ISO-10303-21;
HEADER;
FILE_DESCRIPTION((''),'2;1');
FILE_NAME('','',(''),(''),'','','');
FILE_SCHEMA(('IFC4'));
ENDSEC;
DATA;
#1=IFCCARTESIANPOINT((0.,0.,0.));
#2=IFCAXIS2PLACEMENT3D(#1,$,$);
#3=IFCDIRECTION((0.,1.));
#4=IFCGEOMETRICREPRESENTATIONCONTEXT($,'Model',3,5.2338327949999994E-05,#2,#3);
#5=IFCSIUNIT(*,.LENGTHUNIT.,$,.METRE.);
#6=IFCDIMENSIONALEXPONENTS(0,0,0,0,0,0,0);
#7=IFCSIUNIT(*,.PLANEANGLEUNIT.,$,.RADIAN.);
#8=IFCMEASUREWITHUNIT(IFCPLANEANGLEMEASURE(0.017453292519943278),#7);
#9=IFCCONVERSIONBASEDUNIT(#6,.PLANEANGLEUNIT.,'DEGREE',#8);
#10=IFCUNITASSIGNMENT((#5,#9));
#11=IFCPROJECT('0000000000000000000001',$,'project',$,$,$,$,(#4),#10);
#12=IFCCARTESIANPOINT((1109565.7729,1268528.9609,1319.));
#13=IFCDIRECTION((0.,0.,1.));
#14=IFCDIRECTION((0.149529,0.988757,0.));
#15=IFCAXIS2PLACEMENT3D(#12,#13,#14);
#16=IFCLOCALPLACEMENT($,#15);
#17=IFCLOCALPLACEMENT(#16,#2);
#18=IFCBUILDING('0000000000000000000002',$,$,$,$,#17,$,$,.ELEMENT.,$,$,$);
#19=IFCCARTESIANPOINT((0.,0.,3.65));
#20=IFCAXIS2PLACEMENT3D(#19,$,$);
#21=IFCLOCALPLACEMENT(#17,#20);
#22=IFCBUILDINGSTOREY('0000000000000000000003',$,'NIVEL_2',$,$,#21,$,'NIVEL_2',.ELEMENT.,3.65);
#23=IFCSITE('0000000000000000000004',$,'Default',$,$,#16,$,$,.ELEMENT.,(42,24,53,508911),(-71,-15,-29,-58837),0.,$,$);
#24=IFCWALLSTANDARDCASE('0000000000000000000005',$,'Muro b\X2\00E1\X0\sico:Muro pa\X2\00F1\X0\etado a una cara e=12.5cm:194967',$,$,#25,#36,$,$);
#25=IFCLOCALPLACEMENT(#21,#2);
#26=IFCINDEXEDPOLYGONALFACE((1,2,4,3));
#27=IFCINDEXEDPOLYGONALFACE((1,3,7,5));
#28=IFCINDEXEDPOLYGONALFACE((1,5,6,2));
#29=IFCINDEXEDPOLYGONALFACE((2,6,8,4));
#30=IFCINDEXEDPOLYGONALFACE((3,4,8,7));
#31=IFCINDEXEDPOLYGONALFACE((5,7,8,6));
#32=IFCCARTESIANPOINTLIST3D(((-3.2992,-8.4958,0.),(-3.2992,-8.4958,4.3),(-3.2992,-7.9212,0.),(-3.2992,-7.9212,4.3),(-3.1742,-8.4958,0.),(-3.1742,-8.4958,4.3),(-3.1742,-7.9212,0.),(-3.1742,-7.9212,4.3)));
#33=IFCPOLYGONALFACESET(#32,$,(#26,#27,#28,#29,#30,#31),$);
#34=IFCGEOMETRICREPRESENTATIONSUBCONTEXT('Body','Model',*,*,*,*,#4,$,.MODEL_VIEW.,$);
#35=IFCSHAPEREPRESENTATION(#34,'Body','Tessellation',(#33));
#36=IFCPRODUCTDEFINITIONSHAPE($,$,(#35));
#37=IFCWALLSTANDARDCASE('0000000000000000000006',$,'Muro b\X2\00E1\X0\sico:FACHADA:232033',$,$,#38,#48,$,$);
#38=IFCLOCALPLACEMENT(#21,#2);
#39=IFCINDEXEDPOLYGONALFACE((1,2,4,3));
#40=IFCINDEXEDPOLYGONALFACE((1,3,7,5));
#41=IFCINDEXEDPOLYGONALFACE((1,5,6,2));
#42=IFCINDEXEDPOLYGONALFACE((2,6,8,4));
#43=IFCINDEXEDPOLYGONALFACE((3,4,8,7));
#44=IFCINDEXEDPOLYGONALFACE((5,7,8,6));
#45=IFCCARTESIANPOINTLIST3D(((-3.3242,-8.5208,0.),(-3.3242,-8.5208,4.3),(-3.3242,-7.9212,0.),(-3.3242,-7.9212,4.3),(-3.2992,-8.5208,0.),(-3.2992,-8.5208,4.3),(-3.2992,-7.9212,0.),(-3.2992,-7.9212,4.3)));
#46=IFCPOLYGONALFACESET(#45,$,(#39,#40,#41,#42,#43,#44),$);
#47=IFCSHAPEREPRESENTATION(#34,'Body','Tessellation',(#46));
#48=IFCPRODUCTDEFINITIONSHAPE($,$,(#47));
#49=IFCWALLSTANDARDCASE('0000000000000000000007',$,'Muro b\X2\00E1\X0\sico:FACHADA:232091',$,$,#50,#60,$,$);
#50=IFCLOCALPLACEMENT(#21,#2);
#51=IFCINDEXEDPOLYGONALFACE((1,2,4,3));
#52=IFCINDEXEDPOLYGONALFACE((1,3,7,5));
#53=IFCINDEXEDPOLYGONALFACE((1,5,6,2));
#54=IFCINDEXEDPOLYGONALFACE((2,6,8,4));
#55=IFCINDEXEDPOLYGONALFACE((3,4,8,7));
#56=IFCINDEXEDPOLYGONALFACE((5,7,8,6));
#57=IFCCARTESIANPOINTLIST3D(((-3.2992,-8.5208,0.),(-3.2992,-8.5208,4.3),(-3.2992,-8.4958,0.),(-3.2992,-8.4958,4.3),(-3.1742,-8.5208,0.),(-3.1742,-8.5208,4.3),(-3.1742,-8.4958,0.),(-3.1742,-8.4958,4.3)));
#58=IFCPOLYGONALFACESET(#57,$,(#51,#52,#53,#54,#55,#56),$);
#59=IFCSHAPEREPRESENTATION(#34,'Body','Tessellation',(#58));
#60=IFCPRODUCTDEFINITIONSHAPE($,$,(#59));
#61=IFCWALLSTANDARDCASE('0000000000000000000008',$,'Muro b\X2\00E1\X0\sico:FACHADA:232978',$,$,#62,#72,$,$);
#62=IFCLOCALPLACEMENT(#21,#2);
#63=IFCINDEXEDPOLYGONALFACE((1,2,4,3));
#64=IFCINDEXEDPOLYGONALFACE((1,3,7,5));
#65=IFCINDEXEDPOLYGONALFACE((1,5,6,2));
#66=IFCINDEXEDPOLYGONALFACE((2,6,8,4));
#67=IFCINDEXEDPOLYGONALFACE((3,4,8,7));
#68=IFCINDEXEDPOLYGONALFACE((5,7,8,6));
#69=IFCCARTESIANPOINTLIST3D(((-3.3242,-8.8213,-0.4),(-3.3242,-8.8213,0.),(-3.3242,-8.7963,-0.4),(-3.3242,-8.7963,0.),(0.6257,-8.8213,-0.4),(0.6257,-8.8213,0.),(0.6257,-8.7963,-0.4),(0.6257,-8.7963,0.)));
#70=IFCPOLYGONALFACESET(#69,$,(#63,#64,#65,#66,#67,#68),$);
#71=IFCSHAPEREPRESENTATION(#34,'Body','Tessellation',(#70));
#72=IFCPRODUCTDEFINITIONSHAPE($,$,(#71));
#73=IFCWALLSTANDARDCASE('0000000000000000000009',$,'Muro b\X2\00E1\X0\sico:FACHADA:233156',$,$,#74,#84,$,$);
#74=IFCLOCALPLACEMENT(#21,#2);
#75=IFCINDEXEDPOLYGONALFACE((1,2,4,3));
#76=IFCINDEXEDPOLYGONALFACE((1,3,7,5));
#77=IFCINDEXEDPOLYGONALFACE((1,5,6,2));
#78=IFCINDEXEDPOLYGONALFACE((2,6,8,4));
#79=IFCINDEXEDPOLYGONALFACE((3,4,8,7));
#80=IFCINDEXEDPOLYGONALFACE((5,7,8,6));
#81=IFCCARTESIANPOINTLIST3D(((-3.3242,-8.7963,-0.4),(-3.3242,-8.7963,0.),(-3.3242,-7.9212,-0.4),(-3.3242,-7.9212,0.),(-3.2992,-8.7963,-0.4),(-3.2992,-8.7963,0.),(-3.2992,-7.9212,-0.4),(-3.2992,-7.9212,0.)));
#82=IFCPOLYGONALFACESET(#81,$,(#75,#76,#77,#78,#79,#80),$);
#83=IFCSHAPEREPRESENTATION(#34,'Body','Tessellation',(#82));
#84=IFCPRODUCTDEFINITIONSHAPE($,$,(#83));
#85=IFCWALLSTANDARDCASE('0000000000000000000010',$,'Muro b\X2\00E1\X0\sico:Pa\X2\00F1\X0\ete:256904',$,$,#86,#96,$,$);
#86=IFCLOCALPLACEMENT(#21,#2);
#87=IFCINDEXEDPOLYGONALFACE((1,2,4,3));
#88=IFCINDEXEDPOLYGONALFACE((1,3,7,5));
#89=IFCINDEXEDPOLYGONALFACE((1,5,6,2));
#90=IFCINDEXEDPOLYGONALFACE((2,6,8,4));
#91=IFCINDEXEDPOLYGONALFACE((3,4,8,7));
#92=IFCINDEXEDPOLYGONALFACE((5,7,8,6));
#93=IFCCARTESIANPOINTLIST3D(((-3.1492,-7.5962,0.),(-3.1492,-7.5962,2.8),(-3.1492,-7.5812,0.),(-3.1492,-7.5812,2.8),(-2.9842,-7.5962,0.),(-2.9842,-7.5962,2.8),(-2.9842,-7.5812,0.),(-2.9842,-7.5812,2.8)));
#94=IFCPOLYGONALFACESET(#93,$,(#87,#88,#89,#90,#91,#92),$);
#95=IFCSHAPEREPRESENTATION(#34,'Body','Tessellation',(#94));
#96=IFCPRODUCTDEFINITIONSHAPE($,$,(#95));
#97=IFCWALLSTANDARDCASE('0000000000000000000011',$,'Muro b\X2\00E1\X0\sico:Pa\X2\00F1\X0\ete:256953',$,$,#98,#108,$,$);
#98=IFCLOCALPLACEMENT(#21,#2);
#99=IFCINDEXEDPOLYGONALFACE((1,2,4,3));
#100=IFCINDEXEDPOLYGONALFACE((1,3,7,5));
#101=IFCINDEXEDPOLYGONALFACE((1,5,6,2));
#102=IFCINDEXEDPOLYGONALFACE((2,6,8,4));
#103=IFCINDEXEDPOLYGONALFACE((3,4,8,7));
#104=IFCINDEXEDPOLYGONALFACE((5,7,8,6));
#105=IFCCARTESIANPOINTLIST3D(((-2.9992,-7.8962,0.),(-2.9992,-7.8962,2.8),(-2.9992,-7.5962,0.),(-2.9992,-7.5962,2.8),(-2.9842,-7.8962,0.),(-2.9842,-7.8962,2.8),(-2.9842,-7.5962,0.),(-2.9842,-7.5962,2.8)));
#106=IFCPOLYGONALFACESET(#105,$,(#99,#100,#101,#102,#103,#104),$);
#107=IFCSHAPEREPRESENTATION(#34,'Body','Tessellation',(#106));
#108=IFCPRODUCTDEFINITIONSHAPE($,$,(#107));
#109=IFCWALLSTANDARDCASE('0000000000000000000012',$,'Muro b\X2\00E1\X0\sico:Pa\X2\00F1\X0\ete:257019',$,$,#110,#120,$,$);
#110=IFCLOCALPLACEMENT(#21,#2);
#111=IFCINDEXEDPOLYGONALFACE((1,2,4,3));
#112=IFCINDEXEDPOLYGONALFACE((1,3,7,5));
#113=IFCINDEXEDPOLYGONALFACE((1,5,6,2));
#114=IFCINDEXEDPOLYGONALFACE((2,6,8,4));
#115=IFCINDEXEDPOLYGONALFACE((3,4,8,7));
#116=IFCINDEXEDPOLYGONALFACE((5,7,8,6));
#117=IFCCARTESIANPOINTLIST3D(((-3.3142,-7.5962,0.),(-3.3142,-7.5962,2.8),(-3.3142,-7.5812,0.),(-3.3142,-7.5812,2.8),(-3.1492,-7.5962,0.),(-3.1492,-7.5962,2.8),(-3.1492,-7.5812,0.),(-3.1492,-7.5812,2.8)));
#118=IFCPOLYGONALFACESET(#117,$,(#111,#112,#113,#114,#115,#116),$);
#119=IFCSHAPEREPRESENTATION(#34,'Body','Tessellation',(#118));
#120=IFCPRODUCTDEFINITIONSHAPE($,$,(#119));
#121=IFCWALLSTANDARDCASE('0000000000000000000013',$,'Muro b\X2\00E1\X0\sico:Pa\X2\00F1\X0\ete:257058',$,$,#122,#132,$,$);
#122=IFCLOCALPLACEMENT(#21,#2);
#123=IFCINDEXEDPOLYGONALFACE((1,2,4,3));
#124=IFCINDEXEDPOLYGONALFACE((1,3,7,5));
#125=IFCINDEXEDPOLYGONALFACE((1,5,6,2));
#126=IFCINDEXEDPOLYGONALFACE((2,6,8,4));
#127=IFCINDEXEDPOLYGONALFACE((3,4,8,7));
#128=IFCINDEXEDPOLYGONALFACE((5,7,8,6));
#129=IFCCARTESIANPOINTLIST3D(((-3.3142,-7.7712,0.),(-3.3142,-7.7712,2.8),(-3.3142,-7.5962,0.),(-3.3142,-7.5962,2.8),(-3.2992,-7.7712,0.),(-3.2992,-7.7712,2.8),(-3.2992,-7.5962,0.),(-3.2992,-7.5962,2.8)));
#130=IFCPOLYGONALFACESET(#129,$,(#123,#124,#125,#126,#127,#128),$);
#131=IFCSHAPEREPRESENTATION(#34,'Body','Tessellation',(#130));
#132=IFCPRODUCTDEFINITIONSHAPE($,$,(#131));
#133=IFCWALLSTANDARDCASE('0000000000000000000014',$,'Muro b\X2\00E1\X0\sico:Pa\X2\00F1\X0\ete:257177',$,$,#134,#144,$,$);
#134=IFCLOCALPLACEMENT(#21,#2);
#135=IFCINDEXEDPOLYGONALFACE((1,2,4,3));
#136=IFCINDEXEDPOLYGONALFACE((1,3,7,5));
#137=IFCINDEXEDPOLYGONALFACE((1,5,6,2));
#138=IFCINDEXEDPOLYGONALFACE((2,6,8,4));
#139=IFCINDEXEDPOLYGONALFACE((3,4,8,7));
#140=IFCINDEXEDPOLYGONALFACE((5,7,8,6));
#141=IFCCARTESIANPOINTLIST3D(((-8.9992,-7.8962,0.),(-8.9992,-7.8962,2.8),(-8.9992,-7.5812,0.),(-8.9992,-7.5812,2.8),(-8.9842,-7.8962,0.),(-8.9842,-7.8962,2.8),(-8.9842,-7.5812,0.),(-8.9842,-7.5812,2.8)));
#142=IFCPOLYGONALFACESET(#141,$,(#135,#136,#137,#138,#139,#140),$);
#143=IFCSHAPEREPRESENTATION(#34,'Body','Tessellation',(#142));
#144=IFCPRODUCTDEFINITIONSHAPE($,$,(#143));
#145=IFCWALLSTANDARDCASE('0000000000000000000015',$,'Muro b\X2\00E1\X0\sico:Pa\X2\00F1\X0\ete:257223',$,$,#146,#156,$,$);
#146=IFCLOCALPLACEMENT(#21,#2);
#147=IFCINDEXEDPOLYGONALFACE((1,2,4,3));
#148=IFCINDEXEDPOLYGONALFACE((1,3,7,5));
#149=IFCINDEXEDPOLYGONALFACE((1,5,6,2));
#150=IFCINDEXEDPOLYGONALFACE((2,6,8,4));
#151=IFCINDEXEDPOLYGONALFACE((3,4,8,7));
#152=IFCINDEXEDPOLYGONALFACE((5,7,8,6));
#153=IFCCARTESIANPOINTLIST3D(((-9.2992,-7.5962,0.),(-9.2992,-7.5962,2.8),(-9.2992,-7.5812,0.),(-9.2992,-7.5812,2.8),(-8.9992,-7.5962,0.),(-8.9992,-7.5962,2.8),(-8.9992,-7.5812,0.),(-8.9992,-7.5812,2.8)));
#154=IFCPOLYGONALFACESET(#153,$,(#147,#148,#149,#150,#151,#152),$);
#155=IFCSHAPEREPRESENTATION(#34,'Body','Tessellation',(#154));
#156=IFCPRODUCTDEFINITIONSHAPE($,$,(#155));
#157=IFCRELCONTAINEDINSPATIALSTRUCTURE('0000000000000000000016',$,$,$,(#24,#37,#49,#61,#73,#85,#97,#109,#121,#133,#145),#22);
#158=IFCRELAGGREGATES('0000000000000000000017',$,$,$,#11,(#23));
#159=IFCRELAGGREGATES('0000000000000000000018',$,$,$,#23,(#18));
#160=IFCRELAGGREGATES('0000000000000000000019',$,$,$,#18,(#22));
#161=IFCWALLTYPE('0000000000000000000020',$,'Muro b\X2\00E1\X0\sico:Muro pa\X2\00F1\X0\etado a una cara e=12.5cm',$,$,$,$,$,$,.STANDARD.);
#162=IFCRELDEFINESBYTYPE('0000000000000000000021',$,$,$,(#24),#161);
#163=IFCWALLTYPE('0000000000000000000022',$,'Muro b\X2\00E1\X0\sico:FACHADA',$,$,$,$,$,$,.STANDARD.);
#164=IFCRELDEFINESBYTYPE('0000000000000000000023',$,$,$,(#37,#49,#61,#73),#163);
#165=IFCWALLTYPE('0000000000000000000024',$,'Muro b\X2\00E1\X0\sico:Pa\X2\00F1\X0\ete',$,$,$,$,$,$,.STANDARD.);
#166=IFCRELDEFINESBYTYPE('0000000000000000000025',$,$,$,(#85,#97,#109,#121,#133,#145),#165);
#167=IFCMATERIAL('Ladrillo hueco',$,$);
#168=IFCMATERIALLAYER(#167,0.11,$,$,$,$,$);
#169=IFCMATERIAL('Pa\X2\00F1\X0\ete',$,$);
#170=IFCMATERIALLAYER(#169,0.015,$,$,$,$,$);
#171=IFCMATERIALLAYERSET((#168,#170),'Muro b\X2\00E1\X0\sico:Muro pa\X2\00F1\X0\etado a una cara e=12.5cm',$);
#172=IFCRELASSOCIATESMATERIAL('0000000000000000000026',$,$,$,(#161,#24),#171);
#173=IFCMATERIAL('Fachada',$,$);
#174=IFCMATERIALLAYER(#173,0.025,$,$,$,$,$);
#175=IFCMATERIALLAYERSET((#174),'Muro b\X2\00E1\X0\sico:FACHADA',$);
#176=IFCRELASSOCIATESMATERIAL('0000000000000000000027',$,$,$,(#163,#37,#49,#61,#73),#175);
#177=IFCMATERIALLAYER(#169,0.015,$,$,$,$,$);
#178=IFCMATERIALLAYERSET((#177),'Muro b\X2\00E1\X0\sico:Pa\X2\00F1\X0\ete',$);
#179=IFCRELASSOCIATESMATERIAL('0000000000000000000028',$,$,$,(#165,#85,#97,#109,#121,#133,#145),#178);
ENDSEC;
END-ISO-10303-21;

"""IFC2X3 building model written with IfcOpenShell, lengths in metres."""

from ifc_helpers import new_model, entity, si_unit, converted_unit, direction, frame, frame_2d, origin, place, context, subcontext, project, spatial, rectangle, extrude, material, layer, layer_set, layer_usage, type_object, element, save


model = new_model("IFC2X3")

# Units and contexts
model_context = context("Model", 3, precision=5.2338327949999994e-05, world=origin(), true_north=direction((0.0, 1.0)))
body_context = subcontext(model_context, "Body", "Model", "MODEL_VIEW")
ifc_project = project(units=[si_unit("LENGTHUNIT", "METRE"), converted_unit("PLANEANGLEUNIT", "DEGREE", entity("IfcPlaneAngleMeasure", 0.017453292519943278), si_unit("PLANEANGLEUNIT", "RADIAN"), dimensions=[0, 0, 0, 0, 0, 0, 0])], contexts=[model_context])

# Site, building, storey
site_placement = place(None, frame((1109565.7729, 1268528.9609, 1319.0), z_axis=(0.0, 0.0, 1.0), x_axis=(0.149529, 0.988757, 0.0)))
site = spatial("IfcSite", under=ifc_project, at=site_placement, Name="Default", CompositionType="ELEMENT", RefLatitude=(42, 24, 53, 508911), RefLongitude=(-71, -15, -29, -58837), RefElevation=0.0)
building_placement = place(site_placement, origin())
building = spatial("IfcBuilding", under=site, at=building_placement, CompositionType="ELEMENT")
storey_placement = place(building_placement, frame((0.0, 0.0, 3.65)))
storey = spatial("IfcBuildingStorey", under=building, at=storey_placement, Name="NIVEL_2", LongName="NIVEL_2", CompositionType="ELEMENT", Elevation=3.65)

# Shared definitions
ifc_material_1 = material(Name="Pañete")
ifc_material_2 = material(Name="Ladrillo hueco")

# Shared definitions
ifc_layer_1 = layer(ifc_material_2, 0.11)
ifc_layer_2 = layer(ifc_material_1, 0.015)
ifc_layer_set_1 = layer_set([ifc_layer_1, ifc_layer_2], Name="Muro básico:Muro pañetado a una cara e=12.5cm")
wall_type_1 = type_object("IfcWallType", Name="Muro básico:Muro pañetado a una cara e=12.5cm", PredefinedType="STANDARD", material=ifc_layer_set_1)

# Walls
ifc_layer_usage_1 = layer_usage(ifc_layer_set_1, "AXIS2", "POSITIVE", -0.0625)
wall_1_placement = place(storey_placement, frame((-3.2367, -7.9212, 0.0), z_axis=(0.0, 0.0, 1.0), x_axis=(0.0, -1.0, 0.0)))
element("IfcWallStandardCase", 1, at=wall_1_placement, inside=storey, type_object=wall_type_1, material=ifc_layer_usage_1, Name="Muro básico:Muro pañetado a una cara e=12.5cm:194967", context=body_context, shape_type="SweptSolid", body=[
    extrude(rectangle(XDim=0.5746, YDim=0.125, at=frame_2d((0.2873, 0.0), x_axis=(-1.0, 0.0))), origin(), (0.0, 0.0, 1.0), 4.3),
])
ifc_material_3 = material(Name="Fachada")
ifc_layer_3 = layer(ifc_material_3, 0.025)
ifc_layer_set_2 = layer_set([ifc_layer_3], Name="Muro básico:FACHADA")
ifc_layer_usage_2 = layer_usage(ifc_layer_set_2, "AXIS2", "POSITIVE", -0.0125)
wall_type_2 = type_object("IfcWallType", Name="Muro básico:FACHADA", PredefinedType="STANDARD", material=ifc_layer_set_2)
wall_2_placement = place(storey_placement, frame((-3.3117, -7.9212, 0.0), z_axis=(0.0, 0.0, 1.0), x_axis=(0.0, -1.0, 0.0)))
element("IfcWallStandardCase", 2, at=wall_2_placement, inside=storey, type_object=wall_type_2, material=ifc_layer_usage_2, Name="Muro básico:FACHADA:232033", context=body_context, shape_type="SweptSolid", body=[
    extrude(rectangle(XDim=0.5996, YDim=0.025, at=frame_2d((0.2998, 0.0), x_axis=(-1.0, 0.0))), origin(), (0.0, 0.0, 1.0), 4.3),
])
ifc_layer_usage_3 = layer_usage(ifc_layer_set_2, "AXIS2", "POSITIVE", -0.0125)
wall_3_placement = place(storey_placement, frame((-3.2992, -8.5083, 0.0)))
element("IfcWallStandardCase", 3, at=wall_3_placement, inside=storey, type_object=wall_type_2, material=ifc_layer_usage_3, Name="Muro básico:FACHADA:232091", context=body_context, shape_type="SweptSolid", body=[
    extrude(rectangle(XDim=0.125, YDim=0.025, at=frame_2d((0.0625, 0.0), x_axis=(-1.0, 0.0))), origin(), (0.0, 0.0, 1.0), 4.3),
])
ifc_layer_usage_4 = layer_usage(ifc_layer_set_2, "AXIS2", "POSITIVE", -0.0125)
wall_4_placement = place(storey_placement, frame((-3.3242, -8.8088, -0.4)))
element("IfcWallStandardCase", 4, at=wall_4_placement, inside=storey, type_object=wall_type_2, material=ifc_layer_usage_4, Name="Muro básico:FACHADA:232978", context=body_context, shape_type="SweptSolid", body=[
    extrude(rectangle(XDim=3.95, YDim=0.025, at=frame_2d((1.975, 0.0), x_axis=(-1.0, 0.0))), origin(), (0.0, 0.0, 1.0), 0.4),
])
ifc_layer_usage_5 = layer_usage(ifc_layer_set_2, "AXIS2", "NEGATIVE", 0.0125)
wall_5_placement = place(storey_placement, frame((-3.3117, -8.7963, -0.4), z_axis=(0.0, 0.0, 1.0), x_axis=(0.0, 1.0, 0.0)))
element("IfcWallStandardCase", 5, at=wall_5_placement, inside=storey, type_object=wall_type_2, material=ifc_layer_usage_5, Name="Muro básico:FACHADA:233156", context=body_context, shape_type="SweptSolid", body=[
    extrude(rectangle(XDim=0.8751, YDim=0.025, at=frame_2d((0.4376, 0.0), x_axis=(-1.0, 0.0))), origin(), (0.0, 0.0, 1.0), 0.4),
])
ifc_layer_4 = layer(ifc_material_1, 0.015)
ifc_layer_set_3 = layer_set([ifc_layer_4], Name="Muro básico:Pañete")
ifc_layer_usage_6 = layer_usage(ifc_layer_set_3, "AXIS2", "NEGATIVE", 0.0075)
wall_type_3 = type_object("IfcWallType", Name="Muro básico:Pañete", PredefinedType="STANDARD", material=ifc_layer_set_3)
wall_6_placement = place(storey_placement, frame((-3.1492, -7.5887, 0.0)))
element("IfcWallStandardCase", 6, at=wall_6_placement, inside=storey, type_object=wall_type_3, material=ifc_layer_usage_6, Name="Muro básico:Pañete:256904", context=body_context, shape_type="SweptSolid", body=[
    extrude(rectangle(XDim=0.165, YDim=0.015, at=frame_2d((0.0825, 0.0), x_axis=(-1.0, 0.0))), origin(), (0.0, 0.0, 1.0), 2.8),
])
ifc_layer_usage_7 = layer_usage(ifc_layer_set_3, "AXIS2", "NEGATIVE", 0.0075)
wall_7_placement = place(storey_placement, frame((-2.9917, -7.5962, 0.0), z_axis=(0.0, 0.0, 1.0), x_axis=(0.0, -1.0, 0.0)))
element("IfcWallStandardCase", 7, at=wall_7_placement, inside=storey, type_object=wall_type_3, material=ifc_layer_usage_7, Name="Muro básico:Pañete:256953", context=body_context, shape_type="SweptSolid", body=[
    extrude(rectangle(XDim=0.3, YDim=0.015, at=frame_2d((0.15, 0.0), x_axis=(-1.0, 0.0))), origin(), (0.0, 0.0, 1.0), 2.8),
])
ifc_layer_usage_8 = layer_usage(ifc_layer_set_3, "AXIS2", "POSITIVE", -0.0075)
wall_8_placement = place(storey_placement, frame((-3.1492, -7.5887, 0.0), z_axis=(0.0, 0.0, 1.0), x_axis=(-1.0, 0.0, 0.0)))
element("IfcWallStandardCase", 8, at=wall_8_placement, inside=storey, type_object=wall_type_3, material=ifc_layer_usage_8, Name="Muro básico:Pañete:257019", context=body_context, shape_type="SweptSolid", body=[
    extrude(rectangle(XDim=0.165, YDim=0.015, at=frame_2d((0.0825, 0.0), x_axis=(-1.0, 0.0))), origin(), (0.0, 0.0, 1.0), 2.8),
])
ifc_layer_usage_9 = layer_usage(ifc_layer_set_3, "AXIS2", "POSITIVE", -0.0075)
wall_9_placement = place(storey_placement, frame((-3.3067, -7.5962, 0.0), z_axis=(0.0, 0.0, 1.0), x_axis=(0.0, -1.0, 0.0)))
element("IfcWallStandardCase", 9, at=wall_9_placement, inside=storey, type_object=wall_type_3, material=ifc_layer_usage_9, Name="Muro básico:Pañete:257058", context=body_context, shape_type="SweptSolid", body=[
    extrude(rectangle(XDim=0.175, YDim=0.015, at=frame_2d((0.0875, 0.0), x_axis=(-1.0, 0.0))), origin(), (0.0, 0.0, 1.0), 2.8),
])
ifc_layer_usage_10 = layer_usage(ifc_layer_set_3, "AXIS2", "POSITIVE", -0.0075)
wall_10_placement = place(storey_placement, frame((-8.9917, -7.8962, 0.0), z_axis=(0.0, 0.0, 1.0), x_axis=(0.0, 1.0, 0.0)))
element("IfcWallStandardCase", 10, at=wall_10_placement, inside=storey, type_object=wall_type_3, material=ifc_layer_usage_10, Name="Muro básico:Pañete:257177", context=body_context, shape_type="SweptSolid", body=[
    extrude(rectangle(XDim=0.315, YDim=0.015, at=frame_2d((0.1575, 0.0), x_axis=(-1.0, 0.0))), origin(), (0.0, 0.0, 1.0), 2.8),
])
ifc_layer_usage_11 = layer_usage(ifc_layer_set_3, "AXIS2", "POSITIVE", -0.0075)
wall_11_placement = place(storey_placement, frame((-8.9992, -7.5887, 0.0), z_axis=(0.0, 0.0, 1.0), x_axis=(-1.0, 0.0, 0.0)))
element("IfcWallStandardCase", 11, at=wall_11_placement, inside=storey, type_object=wall_type_3, material=ifc_layer_usage_11, Name="Muro básico:Pañete:257223", context=body_context, shape_type="SweptSolid", body=[
    extrude(rectangle(XDim=0.3, YDim=0.015, at=frame_2d((0.15, 0.0), x_axis=(-1.0, 0.0))), origin(), (0.0, 0.0, 1.0), 2.8),
])

save(model, "model.ifc")
